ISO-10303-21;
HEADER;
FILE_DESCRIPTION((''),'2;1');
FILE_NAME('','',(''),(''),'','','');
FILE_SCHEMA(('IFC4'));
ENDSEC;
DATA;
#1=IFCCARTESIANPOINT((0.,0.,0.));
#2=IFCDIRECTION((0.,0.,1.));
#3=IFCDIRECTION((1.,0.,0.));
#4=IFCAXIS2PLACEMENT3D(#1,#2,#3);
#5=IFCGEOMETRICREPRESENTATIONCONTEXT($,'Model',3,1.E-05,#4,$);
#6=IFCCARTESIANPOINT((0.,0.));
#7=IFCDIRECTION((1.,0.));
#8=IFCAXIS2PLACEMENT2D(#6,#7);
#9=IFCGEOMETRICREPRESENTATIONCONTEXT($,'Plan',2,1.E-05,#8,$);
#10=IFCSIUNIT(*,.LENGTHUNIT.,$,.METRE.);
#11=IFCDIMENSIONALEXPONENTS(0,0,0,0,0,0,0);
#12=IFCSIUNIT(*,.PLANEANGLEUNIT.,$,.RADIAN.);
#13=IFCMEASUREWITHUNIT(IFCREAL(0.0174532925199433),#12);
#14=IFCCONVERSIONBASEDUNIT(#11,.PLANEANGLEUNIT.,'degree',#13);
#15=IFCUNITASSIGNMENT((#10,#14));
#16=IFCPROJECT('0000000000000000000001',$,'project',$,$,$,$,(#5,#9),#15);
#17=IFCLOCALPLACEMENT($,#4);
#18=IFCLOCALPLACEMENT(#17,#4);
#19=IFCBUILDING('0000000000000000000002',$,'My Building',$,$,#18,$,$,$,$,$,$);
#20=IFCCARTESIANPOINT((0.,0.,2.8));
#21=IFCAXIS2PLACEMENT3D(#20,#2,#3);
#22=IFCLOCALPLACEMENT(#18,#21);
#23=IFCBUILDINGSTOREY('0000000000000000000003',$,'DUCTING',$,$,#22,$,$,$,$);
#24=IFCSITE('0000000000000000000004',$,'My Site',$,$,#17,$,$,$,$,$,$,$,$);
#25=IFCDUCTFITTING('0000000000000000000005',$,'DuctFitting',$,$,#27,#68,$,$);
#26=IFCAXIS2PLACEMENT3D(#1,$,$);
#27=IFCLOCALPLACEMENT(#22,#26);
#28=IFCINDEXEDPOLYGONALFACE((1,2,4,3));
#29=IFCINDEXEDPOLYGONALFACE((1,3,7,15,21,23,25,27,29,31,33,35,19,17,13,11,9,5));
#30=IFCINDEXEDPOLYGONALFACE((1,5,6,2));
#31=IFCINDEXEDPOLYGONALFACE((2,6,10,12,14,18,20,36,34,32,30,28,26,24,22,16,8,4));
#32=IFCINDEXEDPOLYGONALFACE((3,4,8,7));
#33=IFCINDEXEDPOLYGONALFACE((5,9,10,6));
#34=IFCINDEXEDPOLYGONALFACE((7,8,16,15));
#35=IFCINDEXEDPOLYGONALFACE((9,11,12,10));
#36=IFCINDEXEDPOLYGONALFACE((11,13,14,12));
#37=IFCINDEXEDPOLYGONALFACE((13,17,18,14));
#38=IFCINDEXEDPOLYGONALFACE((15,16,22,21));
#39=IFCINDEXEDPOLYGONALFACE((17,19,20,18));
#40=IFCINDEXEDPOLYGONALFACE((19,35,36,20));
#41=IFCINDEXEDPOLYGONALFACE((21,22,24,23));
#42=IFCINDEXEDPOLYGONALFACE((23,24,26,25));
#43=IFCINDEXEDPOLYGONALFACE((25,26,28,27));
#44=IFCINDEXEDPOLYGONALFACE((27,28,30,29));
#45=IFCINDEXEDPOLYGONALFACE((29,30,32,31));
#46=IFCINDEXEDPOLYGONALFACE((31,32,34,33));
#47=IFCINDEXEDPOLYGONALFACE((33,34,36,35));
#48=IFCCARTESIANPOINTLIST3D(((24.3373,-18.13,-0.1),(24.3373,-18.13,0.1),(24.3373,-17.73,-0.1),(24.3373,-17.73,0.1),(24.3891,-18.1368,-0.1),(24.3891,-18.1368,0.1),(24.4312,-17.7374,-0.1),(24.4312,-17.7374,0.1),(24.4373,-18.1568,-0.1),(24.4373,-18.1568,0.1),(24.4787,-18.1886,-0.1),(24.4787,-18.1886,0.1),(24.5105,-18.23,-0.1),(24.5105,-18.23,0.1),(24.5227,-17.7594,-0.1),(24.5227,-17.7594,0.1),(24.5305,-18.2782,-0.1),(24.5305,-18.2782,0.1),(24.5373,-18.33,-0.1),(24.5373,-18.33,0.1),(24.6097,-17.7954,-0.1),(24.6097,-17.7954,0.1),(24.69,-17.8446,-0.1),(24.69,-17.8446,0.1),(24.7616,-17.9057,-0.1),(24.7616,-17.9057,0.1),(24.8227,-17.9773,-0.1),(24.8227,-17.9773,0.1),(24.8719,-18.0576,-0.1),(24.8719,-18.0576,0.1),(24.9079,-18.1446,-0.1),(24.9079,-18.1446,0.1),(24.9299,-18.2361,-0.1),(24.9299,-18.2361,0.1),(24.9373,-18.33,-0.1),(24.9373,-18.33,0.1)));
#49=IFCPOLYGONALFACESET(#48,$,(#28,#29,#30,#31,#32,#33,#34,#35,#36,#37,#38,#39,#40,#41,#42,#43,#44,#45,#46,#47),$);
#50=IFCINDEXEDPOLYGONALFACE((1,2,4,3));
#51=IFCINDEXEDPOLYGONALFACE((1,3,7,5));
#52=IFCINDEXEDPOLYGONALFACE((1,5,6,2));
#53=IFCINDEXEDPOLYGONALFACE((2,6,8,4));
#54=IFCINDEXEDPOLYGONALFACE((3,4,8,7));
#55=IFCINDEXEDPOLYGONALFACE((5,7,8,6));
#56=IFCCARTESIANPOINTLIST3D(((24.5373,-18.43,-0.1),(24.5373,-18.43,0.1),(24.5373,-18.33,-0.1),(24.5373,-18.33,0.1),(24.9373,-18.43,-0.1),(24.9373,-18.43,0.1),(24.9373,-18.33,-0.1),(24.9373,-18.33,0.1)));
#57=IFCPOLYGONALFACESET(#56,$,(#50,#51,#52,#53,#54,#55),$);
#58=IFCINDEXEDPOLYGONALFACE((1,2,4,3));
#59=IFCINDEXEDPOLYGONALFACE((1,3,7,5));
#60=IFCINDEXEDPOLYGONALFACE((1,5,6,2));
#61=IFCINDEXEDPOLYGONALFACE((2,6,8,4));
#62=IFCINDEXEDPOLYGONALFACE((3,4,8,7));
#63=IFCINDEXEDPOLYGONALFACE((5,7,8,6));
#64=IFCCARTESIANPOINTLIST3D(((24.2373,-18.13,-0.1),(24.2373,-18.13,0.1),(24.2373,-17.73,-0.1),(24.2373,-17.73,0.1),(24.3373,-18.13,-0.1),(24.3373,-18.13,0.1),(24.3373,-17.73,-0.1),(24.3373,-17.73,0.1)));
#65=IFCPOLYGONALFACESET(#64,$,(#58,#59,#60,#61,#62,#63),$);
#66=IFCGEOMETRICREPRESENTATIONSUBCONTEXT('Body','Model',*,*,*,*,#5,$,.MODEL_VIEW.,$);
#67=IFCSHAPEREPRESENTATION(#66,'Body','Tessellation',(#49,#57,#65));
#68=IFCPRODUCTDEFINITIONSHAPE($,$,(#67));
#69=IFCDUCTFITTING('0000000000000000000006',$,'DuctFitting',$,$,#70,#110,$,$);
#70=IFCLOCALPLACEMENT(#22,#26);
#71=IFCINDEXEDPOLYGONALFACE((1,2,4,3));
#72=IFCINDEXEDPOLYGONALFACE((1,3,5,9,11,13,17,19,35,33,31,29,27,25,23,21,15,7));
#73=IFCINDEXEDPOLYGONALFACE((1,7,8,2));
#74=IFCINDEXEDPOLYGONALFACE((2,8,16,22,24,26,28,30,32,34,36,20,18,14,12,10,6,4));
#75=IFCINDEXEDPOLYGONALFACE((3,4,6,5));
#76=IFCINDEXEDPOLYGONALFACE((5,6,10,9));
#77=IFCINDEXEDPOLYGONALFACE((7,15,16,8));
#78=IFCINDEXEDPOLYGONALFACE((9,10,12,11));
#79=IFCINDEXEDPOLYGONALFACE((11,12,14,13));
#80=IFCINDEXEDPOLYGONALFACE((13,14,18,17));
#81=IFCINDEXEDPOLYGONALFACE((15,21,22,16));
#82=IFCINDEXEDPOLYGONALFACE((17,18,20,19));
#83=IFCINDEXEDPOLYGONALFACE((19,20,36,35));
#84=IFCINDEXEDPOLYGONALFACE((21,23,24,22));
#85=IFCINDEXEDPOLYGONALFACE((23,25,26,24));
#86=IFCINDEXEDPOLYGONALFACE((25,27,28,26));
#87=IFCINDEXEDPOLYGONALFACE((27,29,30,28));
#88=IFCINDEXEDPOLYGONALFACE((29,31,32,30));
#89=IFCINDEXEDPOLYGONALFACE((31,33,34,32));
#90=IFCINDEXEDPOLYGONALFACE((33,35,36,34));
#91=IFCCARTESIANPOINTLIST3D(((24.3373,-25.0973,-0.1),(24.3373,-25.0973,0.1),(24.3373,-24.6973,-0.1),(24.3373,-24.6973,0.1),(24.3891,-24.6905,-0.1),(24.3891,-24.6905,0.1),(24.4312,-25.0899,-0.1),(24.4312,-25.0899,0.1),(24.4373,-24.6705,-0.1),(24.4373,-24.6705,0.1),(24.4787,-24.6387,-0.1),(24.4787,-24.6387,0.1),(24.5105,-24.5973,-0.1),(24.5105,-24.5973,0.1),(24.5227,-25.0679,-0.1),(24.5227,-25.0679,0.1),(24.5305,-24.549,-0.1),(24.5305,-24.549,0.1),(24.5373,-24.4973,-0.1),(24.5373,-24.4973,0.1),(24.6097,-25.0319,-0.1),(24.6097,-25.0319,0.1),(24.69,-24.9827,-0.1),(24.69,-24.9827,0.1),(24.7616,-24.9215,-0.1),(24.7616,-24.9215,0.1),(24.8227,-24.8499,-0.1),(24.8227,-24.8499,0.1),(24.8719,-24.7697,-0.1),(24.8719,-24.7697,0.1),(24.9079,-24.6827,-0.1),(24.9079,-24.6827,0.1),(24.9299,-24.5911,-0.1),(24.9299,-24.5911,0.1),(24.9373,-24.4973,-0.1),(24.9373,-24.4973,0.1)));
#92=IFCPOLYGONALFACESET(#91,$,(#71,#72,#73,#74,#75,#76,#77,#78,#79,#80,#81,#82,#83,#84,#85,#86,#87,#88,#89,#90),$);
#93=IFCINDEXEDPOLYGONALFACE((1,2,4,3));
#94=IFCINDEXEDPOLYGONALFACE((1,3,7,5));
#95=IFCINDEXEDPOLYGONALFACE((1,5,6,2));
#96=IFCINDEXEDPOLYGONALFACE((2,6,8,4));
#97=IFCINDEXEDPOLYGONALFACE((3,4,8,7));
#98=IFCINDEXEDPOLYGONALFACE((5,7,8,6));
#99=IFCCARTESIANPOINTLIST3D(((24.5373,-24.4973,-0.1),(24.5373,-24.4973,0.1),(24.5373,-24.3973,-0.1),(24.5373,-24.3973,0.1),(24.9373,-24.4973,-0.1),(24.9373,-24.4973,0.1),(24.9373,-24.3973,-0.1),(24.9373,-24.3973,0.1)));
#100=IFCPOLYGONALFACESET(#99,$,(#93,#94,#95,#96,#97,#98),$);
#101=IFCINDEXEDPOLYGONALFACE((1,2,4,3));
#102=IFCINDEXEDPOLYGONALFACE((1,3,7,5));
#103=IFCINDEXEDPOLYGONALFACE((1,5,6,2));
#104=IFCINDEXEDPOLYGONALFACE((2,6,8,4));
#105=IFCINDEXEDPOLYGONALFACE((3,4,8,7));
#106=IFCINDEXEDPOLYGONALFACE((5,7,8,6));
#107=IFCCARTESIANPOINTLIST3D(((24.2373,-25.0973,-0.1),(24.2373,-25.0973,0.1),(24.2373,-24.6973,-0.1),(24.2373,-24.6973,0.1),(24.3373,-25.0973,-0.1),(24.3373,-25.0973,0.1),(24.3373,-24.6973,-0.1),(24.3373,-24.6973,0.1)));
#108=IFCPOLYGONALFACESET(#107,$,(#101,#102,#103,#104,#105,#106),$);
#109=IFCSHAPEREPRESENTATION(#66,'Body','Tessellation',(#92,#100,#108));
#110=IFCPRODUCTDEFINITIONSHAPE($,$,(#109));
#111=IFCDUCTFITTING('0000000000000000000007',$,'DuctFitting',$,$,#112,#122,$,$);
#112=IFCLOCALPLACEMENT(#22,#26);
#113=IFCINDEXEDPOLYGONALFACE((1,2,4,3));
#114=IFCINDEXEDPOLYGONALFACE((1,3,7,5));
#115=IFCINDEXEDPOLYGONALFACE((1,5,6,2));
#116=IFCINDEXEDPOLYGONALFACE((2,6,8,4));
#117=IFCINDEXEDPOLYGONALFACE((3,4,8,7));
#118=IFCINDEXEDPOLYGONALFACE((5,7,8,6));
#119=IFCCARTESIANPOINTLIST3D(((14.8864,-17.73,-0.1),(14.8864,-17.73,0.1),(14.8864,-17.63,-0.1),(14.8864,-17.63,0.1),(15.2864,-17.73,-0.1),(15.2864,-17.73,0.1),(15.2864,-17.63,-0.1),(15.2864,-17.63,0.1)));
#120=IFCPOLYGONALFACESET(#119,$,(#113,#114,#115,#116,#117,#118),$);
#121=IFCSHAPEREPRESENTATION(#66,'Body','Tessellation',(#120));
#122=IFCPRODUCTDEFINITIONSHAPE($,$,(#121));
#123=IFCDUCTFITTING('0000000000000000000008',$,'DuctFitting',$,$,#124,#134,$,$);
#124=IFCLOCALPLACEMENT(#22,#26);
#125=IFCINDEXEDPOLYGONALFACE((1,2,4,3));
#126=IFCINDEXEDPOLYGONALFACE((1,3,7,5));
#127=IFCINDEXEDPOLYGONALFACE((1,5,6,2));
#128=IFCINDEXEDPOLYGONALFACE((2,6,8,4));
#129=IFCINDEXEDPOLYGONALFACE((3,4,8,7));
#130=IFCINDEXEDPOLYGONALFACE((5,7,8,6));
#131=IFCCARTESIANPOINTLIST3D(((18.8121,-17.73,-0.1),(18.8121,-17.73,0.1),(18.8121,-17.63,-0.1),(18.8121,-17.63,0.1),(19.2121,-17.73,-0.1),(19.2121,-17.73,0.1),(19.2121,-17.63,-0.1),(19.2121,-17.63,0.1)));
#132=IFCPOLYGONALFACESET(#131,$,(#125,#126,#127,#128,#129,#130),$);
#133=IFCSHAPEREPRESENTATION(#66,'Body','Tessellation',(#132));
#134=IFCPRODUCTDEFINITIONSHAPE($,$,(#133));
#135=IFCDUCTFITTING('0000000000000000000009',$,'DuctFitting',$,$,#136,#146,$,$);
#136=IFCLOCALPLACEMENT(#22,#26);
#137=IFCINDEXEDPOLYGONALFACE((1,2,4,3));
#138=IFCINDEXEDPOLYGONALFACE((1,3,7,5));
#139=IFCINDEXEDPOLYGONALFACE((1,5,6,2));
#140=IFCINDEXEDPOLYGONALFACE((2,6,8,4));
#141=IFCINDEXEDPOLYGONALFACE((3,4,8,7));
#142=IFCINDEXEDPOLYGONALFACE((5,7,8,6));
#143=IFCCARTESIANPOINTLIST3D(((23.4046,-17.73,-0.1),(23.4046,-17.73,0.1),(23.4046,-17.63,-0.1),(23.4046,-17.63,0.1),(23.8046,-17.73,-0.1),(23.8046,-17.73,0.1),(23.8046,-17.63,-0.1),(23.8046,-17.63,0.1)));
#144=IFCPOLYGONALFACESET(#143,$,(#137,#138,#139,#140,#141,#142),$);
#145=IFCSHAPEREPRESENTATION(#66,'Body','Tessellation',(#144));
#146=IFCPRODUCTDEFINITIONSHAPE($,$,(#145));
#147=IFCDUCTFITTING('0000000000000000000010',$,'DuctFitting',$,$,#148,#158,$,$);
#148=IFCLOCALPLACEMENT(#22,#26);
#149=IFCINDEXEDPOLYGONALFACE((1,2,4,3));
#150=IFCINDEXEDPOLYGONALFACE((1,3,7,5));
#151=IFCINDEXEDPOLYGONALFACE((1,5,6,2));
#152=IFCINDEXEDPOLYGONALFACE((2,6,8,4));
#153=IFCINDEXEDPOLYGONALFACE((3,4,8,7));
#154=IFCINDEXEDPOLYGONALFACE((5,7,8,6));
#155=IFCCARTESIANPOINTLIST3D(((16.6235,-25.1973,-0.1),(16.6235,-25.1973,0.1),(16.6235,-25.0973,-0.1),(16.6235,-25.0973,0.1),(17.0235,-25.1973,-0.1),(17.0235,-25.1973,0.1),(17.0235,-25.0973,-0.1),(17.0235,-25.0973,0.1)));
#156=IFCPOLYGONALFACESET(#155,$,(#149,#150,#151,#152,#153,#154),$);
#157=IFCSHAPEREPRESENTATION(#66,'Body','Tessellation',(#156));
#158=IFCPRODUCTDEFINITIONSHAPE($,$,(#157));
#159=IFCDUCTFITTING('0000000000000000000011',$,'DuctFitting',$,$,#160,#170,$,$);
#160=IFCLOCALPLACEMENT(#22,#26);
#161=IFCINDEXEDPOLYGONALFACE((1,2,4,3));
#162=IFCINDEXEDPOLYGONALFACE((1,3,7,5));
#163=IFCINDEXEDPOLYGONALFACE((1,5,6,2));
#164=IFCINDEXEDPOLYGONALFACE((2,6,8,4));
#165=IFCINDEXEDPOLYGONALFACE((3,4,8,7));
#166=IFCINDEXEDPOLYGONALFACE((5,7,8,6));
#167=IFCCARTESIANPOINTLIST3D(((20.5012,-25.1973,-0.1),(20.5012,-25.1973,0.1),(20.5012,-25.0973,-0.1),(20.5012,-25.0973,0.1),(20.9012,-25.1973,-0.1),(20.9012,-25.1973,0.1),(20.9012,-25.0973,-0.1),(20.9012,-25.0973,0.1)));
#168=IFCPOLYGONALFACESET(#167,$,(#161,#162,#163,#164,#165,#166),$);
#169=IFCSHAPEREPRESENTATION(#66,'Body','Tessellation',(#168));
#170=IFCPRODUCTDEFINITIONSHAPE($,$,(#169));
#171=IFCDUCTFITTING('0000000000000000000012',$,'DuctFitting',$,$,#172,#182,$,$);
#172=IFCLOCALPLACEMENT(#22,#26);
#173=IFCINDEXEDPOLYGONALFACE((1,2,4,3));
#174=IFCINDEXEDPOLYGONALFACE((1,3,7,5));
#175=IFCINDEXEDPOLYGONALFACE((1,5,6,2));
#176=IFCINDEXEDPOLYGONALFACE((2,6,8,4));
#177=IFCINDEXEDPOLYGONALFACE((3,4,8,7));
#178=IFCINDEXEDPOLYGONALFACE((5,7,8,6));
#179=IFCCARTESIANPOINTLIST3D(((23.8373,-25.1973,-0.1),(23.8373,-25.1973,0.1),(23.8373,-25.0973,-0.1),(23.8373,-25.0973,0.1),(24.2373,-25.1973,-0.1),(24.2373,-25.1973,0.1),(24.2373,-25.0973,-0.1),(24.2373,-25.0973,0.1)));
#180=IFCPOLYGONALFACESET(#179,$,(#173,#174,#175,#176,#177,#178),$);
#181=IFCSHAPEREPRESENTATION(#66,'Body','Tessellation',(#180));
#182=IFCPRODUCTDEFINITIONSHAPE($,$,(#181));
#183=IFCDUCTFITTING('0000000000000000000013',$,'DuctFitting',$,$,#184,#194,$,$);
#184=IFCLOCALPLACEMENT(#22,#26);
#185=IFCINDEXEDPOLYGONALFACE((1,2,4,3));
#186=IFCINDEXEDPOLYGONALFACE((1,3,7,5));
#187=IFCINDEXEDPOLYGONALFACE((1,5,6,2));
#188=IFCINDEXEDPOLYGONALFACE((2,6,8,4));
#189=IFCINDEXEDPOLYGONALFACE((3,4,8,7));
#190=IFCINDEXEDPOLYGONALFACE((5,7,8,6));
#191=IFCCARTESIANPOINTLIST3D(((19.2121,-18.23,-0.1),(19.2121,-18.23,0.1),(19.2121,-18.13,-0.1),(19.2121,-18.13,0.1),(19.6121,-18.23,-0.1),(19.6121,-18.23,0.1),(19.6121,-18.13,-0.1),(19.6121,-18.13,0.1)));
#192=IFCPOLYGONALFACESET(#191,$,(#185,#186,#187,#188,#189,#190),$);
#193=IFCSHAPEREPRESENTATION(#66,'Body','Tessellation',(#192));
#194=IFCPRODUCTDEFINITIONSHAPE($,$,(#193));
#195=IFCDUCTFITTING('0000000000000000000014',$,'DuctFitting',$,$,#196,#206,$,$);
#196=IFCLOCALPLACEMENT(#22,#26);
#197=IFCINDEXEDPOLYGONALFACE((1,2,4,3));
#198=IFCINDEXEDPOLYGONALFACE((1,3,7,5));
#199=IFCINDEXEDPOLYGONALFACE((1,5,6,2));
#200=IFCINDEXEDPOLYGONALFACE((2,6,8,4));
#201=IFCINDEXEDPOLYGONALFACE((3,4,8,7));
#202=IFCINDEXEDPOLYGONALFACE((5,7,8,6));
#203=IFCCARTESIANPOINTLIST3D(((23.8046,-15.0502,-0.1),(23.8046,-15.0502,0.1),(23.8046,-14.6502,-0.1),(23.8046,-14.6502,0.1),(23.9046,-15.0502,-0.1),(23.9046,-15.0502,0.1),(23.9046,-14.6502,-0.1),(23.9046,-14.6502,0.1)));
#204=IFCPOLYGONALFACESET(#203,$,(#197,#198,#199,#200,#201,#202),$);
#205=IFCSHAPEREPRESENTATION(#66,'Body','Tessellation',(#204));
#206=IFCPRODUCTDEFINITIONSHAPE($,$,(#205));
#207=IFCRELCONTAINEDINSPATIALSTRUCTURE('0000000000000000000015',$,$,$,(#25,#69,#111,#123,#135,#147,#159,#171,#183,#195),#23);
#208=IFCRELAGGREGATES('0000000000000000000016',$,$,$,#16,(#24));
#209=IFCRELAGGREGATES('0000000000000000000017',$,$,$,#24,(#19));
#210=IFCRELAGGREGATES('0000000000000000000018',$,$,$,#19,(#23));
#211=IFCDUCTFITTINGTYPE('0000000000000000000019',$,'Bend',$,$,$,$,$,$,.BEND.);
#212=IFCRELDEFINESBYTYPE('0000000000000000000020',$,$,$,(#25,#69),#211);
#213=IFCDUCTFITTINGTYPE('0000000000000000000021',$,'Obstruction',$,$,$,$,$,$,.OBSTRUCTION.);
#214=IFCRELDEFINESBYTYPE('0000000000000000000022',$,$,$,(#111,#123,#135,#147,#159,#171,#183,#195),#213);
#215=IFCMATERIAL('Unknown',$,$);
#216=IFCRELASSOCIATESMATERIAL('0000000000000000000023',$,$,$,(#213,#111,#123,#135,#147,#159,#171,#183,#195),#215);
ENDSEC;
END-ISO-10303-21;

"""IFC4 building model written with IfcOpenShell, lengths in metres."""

from ifc_helpers import new_model, entity, si_unit, converted_unit, frame, origin_with_axes, origin_2d_with_axis, place, context, subcontext, project, spatial, line, arc, indexed_curve, rectangle, outline, extrude, source, transform, mapped, material, material_profile, profile_set, profile_usage, type_object, type_shapes, element, save


model = new_model("IFC4")

# Units and contexts
model_context = context("Model", 3, precision=1e-05, world=origin_with_axes())
plan_context = context("Plan", 2, precision=1e-05, world=origin_2d_with_axis())
body_context = subcontext(model_context, "Body", "Model", "MODEL_VIEW")
ifc_project = project(units=[si_unit("LENGTHUNIT", "METRE"), converted_unit("PLANEANGLEUNIT", "degree", entity("IfcReal", 0.0174532925199433), si_unit("PLANEANGLEUNIT", "RADIAN"), dimensions=[0, 0, 0, 0, 0, 0, 0])], contexts=[model_context, plan_context])

# Site, building, storey
site_placement = place(None, origin_with_axes())
site = spatial("IfcSite", under=ifc_project, at=site_placement, Name="My Site")
building_placement = place(site_placement, origin_with_axes())
building = spatial("IfcBuilding", under=site, at=building_placement, Name="My Building")
storey_placement = place(building_placement, frame((0.0, 0.0, 2.8), z_axis=(0.0, 0.0, 1.0), x_axis=(1.0, 0.0, 0.0)))
storey = spatial("IfcBuildingStorey", under=building, at=storey_placement, Name="DUCTING")

# Shared definitions
ifc_material = material(Name="Unknown")

# Duct fittings
duct_fitting_type_1 = type_object("IfcDuctFittingType", Name="Bend", PredefinedType="BEND")
shared_shape = source(origin_with_axes(), body_context, "Body", "SweptSolid", [
    extrude(outline(indexed_curve([(0.2, 0.0), (0.2586, 0.1414), (0.4, 0.2), (0.4, 0.6), (-0.0243, 0.4243), (-0.2, 0.0)], segments=[arc(1, 2, 3), line(3, 4), arc(4, 5, 6), line(6, 1)])), frame((0.0, -0.1, 0.1), z_axis=(0.0, -1.0, 0.0), x_axis=(1.0, 0.0, 0.0)), (0.0, 0.0, -1.0), 0.2),
    extrude(rectangle(XDim=0.4, YDim=0.2), origin_with_axes(), (0.0, 0.0, 1.0), 0.1),
    extrude(rectangle(XDim=0.4, YDim=0.2), frame((0.4, 0.0, 0.5), z_axis=(1.0, 0.0, 0.0), x_axis=(0.0, 0.0, 1.0)), (0.0, 0.0, 1.0), 0.1),
])
type_shapes(duct_fitting_type_1, [shared_shape])
for number, where, z_axis, x_axis, name in (
    (1, (24.7373, -18.43, 0.0), (0.0, 1.0, 0.0), (-1.0, 0.0, 0.0), "DuctFitting"),
    (2, (24.7373, -24.3973, 0.0), (0.0, -1.0, 0.0), (-1.0, 0.0, 0.0), "DuctFitting"),
):
    element("IfcDuctFitting", number, at=place(storey_placement, frame(where, z_axis=z_axis, x_axis=x_axis)), inside=storey, type_object=duct_fitting_type_1, Name=name, context=body_context, shape_type="MappedRepresentation", body=[
        mapped(shared_shape, transform((0.0, 0.0, 0.0), x_axis=(1.0, 0.0, 0.0), y_axis=(0.0, 1.0, 0.0), z_axis=(0.0, 0.0, 1.0), scale=1.0)),
    ])
ifc_material_profile_1 = material_profile(ifc_material, rectangle(XDim=0.4, YDim=0.2))
ifc_profile_set_1 = profile_set([ifc_material_profile_1])
ifc_profile_usage_1 = profile_usage(ifc_profile_set_1, cardinal=5)
duct_fitting_type_2 = type_object("IfcDuctFittingType", Name="Obstruction", PredefinedType="OBSTRUCTION", material=ifc_profile_set_1)
duct_fitting_1_placement = place(storey_placement, frame((15.0864, -17.73, 0.0), z_axis=(0.0, 1.0, 0.0), x_axis=(-1.0, 0.0, 0.0)))
element("IfcDuctFitting", 3, at=duct_fitting_1_placement, inside=storey, type_object=duct_fitting_type_2, material=ifc_profile_usage_1, Name="DuctFitting", context=body_context, shape_type="SweptSolid", body=[
    extrude(rectangle(XDim=0.4, YDim=0.2), origin_with_axes(), (0.0, 0.0, 1.0), 0.1),
])
ifc_profile_usage_2 = profile_usage(ifc_profile_set_1, cardinal=5)
duct_fitting_2_placement = place(storey_placement, frame((19.0121, -17.73, 0.0), z_axis=(0.0, 1.0, 0.0), x_axis=(-1.0, 0.0, 0.0)))
element("IfcDuctFitting", 4, at=duct_fitting_2_placement, inside=storey, type_object=duct_fitting_type_2, material=ifc_profile_usage_2, Name="DuctFitting", context=body_context, shape_type="SweptSolid", body=[
    extrude(rectangle(XDim=0.4, YDim=0.2), origin_with_axes(), (0.0, 0.0, 1.0), 0.1),
])
ifc_profile_usage_3 = profile_usage(ifc_profile_set_1, cardinal=5)
duct_fitting_3_placement = place(storey_placement, frame((23.6046, -17.73, 0.0), z_axis=(0.0, 1.0, 0.0), x_axis=(-1.0, 0.0, 0.0)))
element("IfcDuctFitting", 5, at=duct_fitting_3_placement, inside=storey, type_object=duct_fitting_type_2, material=ifc_profile_usage_3, Name="DuctFitting", context=body_context, shape_type="SweptSolid", body=[
    extrude(rectangle(XDim=0.4, YDim=0.2), origin_with_axes(), (0.0, 0.0, 1.0), 0.1),
])
ifc_profile_usage_4 = profile_usage(ifc_profile_set_1, cardinal=5)
duct_fitting_4_placement = place(storey_placement, frame((16.8235, -25.0973, 0.0), z_axis=(0.0, -1.0, 0.0), x_axis=(1.0, 0.0, 0.0)))
element("IfcDuctFitting", 6, at=duct_fitting_4_placement, inside=storey, type_object=duct_fitting_type_2, material=ifc_profile_usage_4, Name="DuctFitting", context=body_context, shape_type="SweptSolid", body=[
    extrude(rectangle(XDim=0.4, YDim=0.2), origin_with_axes(), (0.0, 0.0, 1.0), 0.1),
])
ifc_profile_usage_5 = profile_usage(ifc_profile_set_1, cardinal=5)
duct_fitting_5_placement = place(storey_placement, frame((20.7012, -25.0973, 0.0), z_axis=(0.0, -1.0, 0.0), x_axis=(1.0, 0.0, 0.0)))
element("IfcDuctFitting", 7, at=duct_fitting_5_placement, inside=storey, type_object=duct_fitting_type_2, material=ifc_profile_usage_5, Name="DuctFitting", context=body_context, shape_type="SweptSolid", body=[
    extrude(rectangle(XDim=0.4, YDim=0.2), origin_with_axes(), (0.0, 0.0, 1.0), 0.1),
])
ifc_profile_usage_6 = profile_usage(ifc_profile_set_1, cardinal=5)
duct_fitting_6_placement = place(storey_placement, frame((24.0373, -25.0973, 0.0), z_axis=(0.0, -1.0, 0.0), x_axis=(1.0, 0.0, 0.0)))
element("IfcDuctFitting", 8, at=duct_fitting_6_placement, inside=storey, type_object=duct_fitting_type_2, material=ifc_profile_usage_6, Name="DuctFitting", context=body_context, shape_type="SweptSolid", body=[
    extrude(rectangle(XDim=0.4, YDim=0.2), origin_with_axes(), (0.0, 0.0, 1.0), 0.1),
])
ifc_profile_usage_7 = profile_usage(ifc_profile_set_1, cardinal=5)
duct_fitting_7_placement = place(storey_placement, frame((19.4121, -18.13, 0.0), z_axis=(0.0, -1.0, 0.0), x_axis=(1.0, 0.0, 0.0)))
element("IfcDuctFitting", 9, at=duct_fitting_7_placement, inside=storey, type_object=duct_fitting_type_2, material=ifc_profile_usage_7, Name="DuctFitting", context=body_context, shape_type="SweptSolid", body=[
    extrude(rectangle(XDim=0.4, YDim=0.2), origin_with_axes(), (0.0, 0.0, 1.0), 0.1),
])
ifc_profile_usage_8 = profile_usage(ifc_profile_set_1, cardinal=5)
duct_fitting_8_placement = place(storey_placement, frame((23.8046, -14.8502, 0.0), z_axis=(1.0, 0.0, 0.0), x_axis=(0.0, 1.0, 0.0)))
element("IfcDuctFitting", 10, at=duct_fitting_8_placement, inside=storey, type_object=duct_fitting_type_2, material=ifc_profile_usage_8, Name="DuctFitting", context=body_context, shape_type="SweptSolid", body=[
    extrude(rectangle(XDim=0.4, YDim=0.2), origin_with_axes(), (0.0, 0.0, 1.0), 0.1),
])

save(model, "model.ifc")
